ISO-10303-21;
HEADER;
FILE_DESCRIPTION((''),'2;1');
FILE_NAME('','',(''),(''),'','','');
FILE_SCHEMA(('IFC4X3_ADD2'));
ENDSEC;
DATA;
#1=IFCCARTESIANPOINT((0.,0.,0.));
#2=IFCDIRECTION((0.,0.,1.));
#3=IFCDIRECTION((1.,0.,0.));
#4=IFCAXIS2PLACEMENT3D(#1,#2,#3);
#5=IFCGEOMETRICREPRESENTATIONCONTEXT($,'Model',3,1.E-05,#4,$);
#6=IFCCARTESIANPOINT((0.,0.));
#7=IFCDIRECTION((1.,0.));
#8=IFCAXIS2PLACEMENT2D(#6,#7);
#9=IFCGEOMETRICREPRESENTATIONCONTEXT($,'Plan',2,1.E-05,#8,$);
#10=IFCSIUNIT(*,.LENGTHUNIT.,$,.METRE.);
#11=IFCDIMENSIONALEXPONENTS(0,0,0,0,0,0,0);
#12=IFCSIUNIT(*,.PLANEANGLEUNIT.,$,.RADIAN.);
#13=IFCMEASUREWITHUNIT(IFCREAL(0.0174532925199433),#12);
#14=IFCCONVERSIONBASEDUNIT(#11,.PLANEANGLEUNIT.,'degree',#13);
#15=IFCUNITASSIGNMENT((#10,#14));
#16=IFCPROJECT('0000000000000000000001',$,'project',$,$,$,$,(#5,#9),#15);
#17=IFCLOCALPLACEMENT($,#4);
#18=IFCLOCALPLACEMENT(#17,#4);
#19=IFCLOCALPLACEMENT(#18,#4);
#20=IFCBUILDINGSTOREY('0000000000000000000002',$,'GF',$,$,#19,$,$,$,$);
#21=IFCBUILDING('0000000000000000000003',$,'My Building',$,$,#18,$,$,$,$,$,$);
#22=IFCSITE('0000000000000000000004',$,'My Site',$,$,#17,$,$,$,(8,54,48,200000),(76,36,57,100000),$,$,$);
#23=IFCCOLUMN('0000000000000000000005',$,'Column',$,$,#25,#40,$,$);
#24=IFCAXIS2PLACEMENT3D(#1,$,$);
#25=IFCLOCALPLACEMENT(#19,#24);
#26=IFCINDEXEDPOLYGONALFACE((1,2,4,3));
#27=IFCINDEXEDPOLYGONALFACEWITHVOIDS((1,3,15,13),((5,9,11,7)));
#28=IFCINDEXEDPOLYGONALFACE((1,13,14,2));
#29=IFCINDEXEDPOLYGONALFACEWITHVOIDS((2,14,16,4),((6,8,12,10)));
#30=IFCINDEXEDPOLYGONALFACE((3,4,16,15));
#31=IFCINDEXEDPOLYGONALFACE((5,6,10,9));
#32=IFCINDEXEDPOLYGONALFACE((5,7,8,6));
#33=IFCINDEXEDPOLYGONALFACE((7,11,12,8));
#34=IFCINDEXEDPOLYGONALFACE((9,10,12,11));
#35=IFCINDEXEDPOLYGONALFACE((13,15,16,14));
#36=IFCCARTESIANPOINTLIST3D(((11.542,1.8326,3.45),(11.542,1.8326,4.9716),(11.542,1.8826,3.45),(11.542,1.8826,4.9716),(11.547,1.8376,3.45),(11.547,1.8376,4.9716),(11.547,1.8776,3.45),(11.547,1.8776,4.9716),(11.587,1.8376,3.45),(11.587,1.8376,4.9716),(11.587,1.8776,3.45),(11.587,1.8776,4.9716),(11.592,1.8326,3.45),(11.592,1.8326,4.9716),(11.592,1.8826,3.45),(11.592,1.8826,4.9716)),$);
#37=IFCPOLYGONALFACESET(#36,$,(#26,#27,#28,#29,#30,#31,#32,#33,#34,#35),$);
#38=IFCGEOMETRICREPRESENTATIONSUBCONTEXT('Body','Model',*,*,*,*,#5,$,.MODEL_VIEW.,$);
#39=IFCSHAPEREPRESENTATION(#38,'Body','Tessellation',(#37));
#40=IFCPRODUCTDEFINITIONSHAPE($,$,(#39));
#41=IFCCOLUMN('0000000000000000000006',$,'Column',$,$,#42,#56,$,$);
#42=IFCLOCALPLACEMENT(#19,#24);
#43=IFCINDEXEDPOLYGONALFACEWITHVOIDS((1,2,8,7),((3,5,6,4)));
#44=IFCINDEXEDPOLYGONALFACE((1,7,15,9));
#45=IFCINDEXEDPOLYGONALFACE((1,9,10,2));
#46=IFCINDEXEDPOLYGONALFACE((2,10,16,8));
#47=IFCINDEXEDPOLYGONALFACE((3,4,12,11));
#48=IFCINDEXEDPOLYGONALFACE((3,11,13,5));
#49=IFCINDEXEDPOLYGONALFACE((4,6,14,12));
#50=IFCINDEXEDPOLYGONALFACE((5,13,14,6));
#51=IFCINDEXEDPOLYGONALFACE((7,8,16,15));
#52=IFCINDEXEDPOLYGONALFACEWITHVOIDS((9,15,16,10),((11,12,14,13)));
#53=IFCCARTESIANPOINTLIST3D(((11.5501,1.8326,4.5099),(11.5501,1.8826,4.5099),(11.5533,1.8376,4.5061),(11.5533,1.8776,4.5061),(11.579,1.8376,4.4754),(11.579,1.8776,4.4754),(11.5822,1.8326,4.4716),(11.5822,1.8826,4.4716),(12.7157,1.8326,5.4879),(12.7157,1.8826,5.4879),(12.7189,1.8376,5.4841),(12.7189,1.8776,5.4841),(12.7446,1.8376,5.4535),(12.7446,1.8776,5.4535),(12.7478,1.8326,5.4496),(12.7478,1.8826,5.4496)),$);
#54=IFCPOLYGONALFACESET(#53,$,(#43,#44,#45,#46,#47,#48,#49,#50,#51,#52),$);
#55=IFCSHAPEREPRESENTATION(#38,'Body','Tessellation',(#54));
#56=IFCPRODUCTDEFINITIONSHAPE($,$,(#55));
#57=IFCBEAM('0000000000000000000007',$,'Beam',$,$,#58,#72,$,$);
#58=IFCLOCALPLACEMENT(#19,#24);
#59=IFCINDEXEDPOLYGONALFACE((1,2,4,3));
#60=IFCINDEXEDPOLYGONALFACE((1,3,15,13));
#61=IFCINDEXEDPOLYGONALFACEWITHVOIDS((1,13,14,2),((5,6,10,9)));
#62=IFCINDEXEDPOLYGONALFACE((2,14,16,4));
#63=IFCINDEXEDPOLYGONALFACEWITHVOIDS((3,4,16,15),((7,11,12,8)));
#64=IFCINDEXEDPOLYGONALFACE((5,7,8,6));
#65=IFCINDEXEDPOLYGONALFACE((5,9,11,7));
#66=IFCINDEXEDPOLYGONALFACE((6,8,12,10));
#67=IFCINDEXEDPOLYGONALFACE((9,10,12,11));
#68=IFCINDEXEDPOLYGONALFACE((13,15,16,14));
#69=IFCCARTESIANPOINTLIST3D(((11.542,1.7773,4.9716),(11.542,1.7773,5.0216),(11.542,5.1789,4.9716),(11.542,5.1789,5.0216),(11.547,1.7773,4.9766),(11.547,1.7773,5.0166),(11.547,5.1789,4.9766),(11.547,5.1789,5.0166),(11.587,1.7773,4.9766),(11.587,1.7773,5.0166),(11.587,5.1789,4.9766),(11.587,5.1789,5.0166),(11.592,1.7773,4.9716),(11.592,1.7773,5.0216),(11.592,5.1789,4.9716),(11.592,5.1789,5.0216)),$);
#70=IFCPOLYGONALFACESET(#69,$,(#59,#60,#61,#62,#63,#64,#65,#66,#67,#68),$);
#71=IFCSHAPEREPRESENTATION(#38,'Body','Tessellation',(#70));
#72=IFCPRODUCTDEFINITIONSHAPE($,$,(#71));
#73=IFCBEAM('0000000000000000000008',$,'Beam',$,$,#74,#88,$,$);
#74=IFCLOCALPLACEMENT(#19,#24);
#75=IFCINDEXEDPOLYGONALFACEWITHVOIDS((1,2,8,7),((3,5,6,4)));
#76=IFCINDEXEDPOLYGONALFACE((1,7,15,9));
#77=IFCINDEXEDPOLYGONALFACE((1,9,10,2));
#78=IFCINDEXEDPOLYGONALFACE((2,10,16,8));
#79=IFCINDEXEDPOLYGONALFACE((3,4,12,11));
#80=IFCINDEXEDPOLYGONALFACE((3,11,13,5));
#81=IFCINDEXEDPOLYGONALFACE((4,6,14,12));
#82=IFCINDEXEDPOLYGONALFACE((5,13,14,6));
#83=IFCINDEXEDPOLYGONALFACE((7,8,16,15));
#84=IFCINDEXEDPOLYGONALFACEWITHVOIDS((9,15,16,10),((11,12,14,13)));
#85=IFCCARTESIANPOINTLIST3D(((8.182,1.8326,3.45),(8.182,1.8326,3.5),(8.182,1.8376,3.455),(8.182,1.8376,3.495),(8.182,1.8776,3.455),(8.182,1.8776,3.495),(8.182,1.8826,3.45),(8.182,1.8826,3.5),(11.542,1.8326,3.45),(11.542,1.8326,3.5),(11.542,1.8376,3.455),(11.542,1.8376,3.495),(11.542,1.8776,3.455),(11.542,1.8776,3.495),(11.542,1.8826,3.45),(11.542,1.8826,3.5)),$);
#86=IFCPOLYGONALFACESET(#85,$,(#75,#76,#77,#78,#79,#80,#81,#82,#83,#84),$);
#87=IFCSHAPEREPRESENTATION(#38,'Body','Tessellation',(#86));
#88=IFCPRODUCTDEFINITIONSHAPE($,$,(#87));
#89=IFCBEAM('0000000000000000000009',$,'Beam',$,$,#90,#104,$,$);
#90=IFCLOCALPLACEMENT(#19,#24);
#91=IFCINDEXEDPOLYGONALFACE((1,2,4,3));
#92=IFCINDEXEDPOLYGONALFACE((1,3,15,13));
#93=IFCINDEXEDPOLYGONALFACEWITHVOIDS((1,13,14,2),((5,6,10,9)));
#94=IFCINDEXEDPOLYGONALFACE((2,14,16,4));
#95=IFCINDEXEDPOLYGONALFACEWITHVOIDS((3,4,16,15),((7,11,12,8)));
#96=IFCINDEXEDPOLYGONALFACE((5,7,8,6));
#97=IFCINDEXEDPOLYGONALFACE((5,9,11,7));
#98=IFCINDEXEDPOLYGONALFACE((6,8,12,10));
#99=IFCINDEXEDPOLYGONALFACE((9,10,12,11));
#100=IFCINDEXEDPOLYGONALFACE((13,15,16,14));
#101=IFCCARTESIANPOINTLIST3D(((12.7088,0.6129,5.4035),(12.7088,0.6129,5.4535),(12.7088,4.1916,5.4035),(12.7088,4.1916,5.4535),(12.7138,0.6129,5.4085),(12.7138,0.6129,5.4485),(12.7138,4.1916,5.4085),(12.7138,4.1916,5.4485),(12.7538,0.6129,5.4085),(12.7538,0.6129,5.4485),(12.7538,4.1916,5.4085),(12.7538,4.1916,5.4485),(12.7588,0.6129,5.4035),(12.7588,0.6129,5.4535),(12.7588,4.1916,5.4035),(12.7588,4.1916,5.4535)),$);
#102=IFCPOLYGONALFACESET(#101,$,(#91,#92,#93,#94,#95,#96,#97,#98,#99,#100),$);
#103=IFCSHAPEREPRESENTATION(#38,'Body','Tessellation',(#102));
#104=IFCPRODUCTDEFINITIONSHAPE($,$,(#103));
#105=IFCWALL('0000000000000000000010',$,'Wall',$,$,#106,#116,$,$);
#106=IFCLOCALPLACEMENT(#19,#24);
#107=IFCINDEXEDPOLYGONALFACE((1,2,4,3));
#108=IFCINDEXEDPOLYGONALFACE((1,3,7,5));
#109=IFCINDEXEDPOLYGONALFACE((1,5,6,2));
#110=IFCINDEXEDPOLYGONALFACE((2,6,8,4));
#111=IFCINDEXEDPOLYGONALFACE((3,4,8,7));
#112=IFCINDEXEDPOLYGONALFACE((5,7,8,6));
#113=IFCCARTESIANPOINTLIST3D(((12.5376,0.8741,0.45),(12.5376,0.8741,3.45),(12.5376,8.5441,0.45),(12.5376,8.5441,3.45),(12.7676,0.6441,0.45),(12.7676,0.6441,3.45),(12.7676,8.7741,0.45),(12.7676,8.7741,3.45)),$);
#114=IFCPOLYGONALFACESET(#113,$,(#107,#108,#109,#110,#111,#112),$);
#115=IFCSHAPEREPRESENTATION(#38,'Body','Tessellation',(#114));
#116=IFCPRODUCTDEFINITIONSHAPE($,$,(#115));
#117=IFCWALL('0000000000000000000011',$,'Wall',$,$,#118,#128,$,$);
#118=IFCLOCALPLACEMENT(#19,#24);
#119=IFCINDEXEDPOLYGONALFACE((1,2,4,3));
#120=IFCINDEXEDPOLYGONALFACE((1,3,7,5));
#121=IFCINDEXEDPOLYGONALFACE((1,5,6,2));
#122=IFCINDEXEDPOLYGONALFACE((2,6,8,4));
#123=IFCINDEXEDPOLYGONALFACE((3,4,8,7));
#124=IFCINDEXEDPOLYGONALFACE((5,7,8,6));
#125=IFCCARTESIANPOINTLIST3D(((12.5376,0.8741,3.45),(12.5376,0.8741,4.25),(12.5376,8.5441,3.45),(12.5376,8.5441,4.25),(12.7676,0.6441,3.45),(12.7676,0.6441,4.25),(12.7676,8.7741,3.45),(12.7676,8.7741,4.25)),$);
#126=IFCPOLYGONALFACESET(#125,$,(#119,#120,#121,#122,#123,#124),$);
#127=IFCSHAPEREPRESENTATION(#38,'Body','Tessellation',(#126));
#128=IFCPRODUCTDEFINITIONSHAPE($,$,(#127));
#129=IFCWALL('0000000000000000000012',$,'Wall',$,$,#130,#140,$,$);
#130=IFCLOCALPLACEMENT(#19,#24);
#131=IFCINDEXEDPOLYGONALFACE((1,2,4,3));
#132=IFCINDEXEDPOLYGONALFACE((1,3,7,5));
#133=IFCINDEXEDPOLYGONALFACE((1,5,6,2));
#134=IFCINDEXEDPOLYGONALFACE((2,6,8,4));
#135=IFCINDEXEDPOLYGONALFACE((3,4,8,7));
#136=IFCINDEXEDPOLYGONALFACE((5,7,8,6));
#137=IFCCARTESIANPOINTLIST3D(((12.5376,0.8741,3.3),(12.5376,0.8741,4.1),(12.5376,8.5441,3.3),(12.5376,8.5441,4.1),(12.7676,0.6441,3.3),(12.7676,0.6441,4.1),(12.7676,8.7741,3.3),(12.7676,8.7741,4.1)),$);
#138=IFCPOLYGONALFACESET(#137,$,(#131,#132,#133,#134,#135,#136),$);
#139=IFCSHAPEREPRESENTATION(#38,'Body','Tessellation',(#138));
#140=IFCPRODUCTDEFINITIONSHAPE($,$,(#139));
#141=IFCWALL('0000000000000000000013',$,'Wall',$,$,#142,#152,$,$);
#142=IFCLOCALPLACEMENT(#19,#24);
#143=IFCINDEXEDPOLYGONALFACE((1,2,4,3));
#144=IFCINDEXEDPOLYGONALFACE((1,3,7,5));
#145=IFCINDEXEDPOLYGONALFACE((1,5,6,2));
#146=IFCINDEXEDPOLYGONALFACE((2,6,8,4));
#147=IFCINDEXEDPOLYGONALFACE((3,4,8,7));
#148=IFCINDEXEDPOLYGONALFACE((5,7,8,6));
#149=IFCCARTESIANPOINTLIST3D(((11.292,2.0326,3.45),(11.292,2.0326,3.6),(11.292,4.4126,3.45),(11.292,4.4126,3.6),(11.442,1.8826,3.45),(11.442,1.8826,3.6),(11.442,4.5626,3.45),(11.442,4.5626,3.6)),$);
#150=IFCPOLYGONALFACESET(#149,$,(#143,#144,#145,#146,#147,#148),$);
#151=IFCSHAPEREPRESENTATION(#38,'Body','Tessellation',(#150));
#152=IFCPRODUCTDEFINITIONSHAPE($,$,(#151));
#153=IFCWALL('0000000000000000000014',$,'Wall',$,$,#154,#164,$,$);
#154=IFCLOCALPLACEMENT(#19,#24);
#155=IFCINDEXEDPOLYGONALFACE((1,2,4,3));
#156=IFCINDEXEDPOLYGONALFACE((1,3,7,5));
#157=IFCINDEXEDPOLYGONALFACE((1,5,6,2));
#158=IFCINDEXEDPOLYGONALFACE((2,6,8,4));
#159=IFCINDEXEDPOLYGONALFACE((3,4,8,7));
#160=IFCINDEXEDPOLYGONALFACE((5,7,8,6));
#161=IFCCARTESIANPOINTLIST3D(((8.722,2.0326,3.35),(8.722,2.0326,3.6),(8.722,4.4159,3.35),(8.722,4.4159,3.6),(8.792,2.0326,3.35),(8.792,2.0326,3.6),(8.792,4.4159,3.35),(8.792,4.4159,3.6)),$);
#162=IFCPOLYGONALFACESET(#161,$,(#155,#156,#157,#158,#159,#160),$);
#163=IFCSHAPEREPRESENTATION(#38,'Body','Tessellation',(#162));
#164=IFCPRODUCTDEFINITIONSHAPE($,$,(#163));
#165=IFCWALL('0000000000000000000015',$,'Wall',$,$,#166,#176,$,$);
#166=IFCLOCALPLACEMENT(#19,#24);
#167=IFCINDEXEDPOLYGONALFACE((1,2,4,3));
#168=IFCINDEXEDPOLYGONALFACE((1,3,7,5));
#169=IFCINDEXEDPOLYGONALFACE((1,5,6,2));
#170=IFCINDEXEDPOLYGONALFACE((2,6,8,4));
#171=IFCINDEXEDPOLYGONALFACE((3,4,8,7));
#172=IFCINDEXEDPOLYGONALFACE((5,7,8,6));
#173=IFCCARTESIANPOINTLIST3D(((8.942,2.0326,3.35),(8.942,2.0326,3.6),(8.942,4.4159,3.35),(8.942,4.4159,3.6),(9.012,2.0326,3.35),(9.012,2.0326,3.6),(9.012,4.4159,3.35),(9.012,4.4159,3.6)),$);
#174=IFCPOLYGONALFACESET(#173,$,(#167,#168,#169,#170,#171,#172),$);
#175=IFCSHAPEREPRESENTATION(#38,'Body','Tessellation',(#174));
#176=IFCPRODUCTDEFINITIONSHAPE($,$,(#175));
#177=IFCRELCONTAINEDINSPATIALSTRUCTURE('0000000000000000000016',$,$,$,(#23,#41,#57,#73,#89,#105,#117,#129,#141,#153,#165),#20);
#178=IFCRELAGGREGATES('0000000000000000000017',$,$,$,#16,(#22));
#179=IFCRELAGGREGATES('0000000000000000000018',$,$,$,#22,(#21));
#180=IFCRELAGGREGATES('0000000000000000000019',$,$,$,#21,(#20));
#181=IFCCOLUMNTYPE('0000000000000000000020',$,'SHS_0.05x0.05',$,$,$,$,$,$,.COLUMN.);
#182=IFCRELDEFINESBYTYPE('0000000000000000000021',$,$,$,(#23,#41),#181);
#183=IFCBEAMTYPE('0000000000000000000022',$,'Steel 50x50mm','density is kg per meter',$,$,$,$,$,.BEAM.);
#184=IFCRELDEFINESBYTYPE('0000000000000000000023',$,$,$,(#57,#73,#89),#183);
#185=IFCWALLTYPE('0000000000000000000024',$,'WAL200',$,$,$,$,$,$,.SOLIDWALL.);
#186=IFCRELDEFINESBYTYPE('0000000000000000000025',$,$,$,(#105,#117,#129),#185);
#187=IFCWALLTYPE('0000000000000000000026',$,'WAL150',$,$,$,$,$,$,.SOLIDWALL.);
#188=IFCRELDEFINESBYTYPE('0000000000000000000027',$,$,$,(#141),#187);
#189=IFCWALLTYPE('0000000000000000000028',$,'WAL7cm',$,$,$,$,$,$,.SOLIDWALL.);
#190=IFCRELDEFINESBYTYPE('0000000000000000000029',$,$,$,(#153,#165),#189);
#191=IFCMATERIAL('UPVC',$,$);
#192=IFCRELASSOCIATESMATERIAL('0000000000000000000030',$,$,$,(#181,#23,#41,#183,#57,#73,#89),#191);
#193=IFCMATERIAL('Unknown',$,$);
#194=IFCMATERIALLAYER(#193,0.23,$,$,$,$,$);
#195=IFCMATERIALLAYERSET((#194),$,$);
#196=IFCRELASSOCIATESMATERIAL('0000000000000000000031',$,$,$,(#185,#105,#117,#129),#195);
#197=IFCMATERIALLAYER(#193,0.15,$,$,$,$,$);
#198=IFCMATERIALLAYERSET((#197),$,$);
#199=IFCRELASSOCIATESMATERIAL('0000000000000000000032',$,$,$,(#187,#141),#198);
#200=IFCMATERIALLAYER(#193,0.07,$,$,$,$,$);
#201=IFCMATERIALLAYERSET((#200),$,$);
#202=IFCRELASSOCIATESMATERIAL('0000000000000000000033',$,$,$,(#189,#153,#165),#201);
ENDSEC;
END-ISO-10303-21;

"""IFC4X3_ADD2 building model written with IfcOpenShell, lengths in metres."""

from ifc_helpers import new_model, entity, si_unit, converted_unit, frame, origin_with_axes, origin_2d_with_axis, place, context, subcontext, project, spatial, line, indexed_curve, hollow_rectangle, outline, extrude, material, layer, layer_set, layer_usage, material_profile, profile_set, profile_usage, type_object, element, save


model = new_model("IFC4X3_ADD2")

# Units and contexts
model_context = context("Model", 3, precision=1e-05, world=origin_with_axes())
plan_context = context("Plan", 2, precision=1e-05, world=origin_2d_with_axis())
body_context = subcontext(model_context, "Body", "Model", "MODEL_VIEW")
ifc_project = project(units=[si_unit("LENGTHUNIT", "METRE"), converted_unit("PLANEANGLEUNIT", "degree", entity("IfcReal", 0.0174532925199433), si_unit("PLANEANGLEUNIT", "RADIAN"), dimensions=[0, 0, 0, 0, 0, 0, 0])], contexts=[model_context, plan_context])

# Site, building, storey
site_placement = place(None, origin_with_axes())
site = spatial("IfcSite", under=ifc_project, at=site_placement, Name="My Site", RefLatitude=(8, 54, 48, 200000), RefLongitude=(76, 36, 57, 100000))
building_placement = place(site_placement, origin_with_axes())
building = spatial("IfcBuilding", under=site, at=building_placement, Name="My Building")
storey_placement = place(building_placement, origin_with_axes())
storey = spatial("IfcBuildingStorey", under=building, at=storey_placement, Name="GF")

# Columns
ifc_material_1 = material(Name="UPVC")
ifc_material_profile_1 = material_profile(ifc_material_1, hollow_rectangle(XDim=0.05, YDim=0.05, WallThickness=0.005))
ifc_profile_set_1 = profile_set([ifc_material_profile_1])
ifc_profile_usage_1 = profile_usage(ifc_profile_set_1, cardinal=5)
column_type = type_object("IfcColumnType", Name="SHS_0.05x0.05", PredefinedType="COLUMN", material=ifc_profile_set_1)
column_1_placement = place(storey_placement, frame((11.567, 1.8576, 3.45), z_axis=(0.0, 0.0, 1.0), x_axis=(1.0, 0.0, 0.0)))
element("IfcColumn", 1, at=column_1_placement, inside=storey, type_object=column_type, material=ifc_profile_usage_1, Name="Column", context=body_context, shape_type="SweptSolid", body=[
    extrude(hollow_rectangle(XDim=0.05, YDim=0.05, WallThickness=0.005), origin_with_axes(), (0.0, 0.0, 1.0), 1.5216),
])
ifc_profile_usage_2 = profile_usage(ifc_profile_set_1, cardinal=5)
column_2_placement = place(storey_placement, frame((11.5662, 1.8576, 4.4907), z_axis=(0.766045, 0.0, 0.642787), x_axis=(0.0, 1.0, 0.0)))
element("IfcColumn", 2, at=column_2_placement, inside=storey, type_object=column_type, material=ifc_profile_usage_2, Name="Column", context=body_context, shape_type="SweptSolid", body=[
    extrude(hollow_rectangle(XDim=0.05, YDim=0.05, WallThickness=0.005), origin_with_axes(), (0.0, 0.0, 1.0), 1.5216),
])

# Beams
ifc_material_profile_2 = material_profile(ifc_material_1, hollow_rectangle(XDim=0.05, YDim=0.05, WallThickness=0.005))
ifc_profile_set_2 = profile_set([ifc_material_profile_2])
ifc_profile_usage_3 = profile_usage(ifc_profile_set_2, cardinal=5)
beam_type = type_object("IfcBeamType", Name="Steel 50x50mm", Description="density is kg per meter", PredefinedType="BEAM", material=ifc_profile_set_2)
beam_1_placement = place(storey_placement, frame((11.567, 5.1789, 4.9966), z_axis=(0.0, -1.0, 0.0), x_axis=(1.0, 0.0, 0.0)))
element("IfcBeam", 3, at=beam_1_placement, inside=storey, type_object=beam_type, material=ifc_profile_usage_3, Name="Beam", context=body_context, shape_type="SweptSolid", body=[
    extrude(hollow_rectangle(XDim=0.05, YDim=0.05, WallThickness=0.005), origin_with_axes(), (0.0, 0.0, 1.0), 3.4016),
])
ifc_profile_usage_4 = profile_usage(ifc_profile_set_2, cardinal=5)
beam_2_placement = place(storey_placement, frame((11.542, 1.8576, 3.475), z_axis=(-1.0, 0.0, 0.0), x_axis=(0.0, -1.0, 0.0)))
element("IfcBeam", 4, at=beam_2_placement, inside=storey, type_object=beam_type, material=ifc_profile_usage_4, Name="Beam", context=body_context, shape_type="SweptSolid", body=[
    extrude(hollow_rectangle(XDim=0.05, YDim=0.05, WallThickness=0.005), origin_with_axes(), (0.0, 0.0, 1.0), 3.36),
])
ifc_profile_usage_5 = profile_usage(ifc_profile_set_2, cardinal=5)
beam_3_placement = place(storey_placement, frame((12.7338, 4.1916, 5.4285), z_axis=(0.0, -1.0, 0.0), x_axis=(1.0, 0.0, 0.0)))
element("IfcBeam", 5, at=beam_3_placement, inside=storey, type_object=beam_type, material=ifc_profile_usage_5, Name="Beam", context=body_context, shape_type="SweptSolid", body=[
    extrude(hollow_rectangle(XDim=0.05, YDim=0.05, WallThickness=0.005), origin_with_axes(), (0.0, 0.0, 1.0), 3.5787),
])

# Walls
ifc_material_2 = material(Name="Unknown")
ifc_layer_1 = layer(ifc_material_2, 0.23)
ifc_layer_set_1 = layer_set([ifc_layer_1])
ifc_layer_usage_1 = layer_usage(ifc_layer_set_1, "AXIS2", "POSITIVE", 0.0)
wall_type_1 = type_object("IfcWallType", Name="WAL200", PredefinedType="SOLIDWALL", material=ifc_layer_set_1)
wall_1_placement = place(storey_placement, frame((12.5376, 8.5441, 0.45), z_axis=(0.0, 0.0, 1.0), x_axis=(0.0, -1.0, 0.0)))
element("IfcWall", 6, at=wall_1_placement, inside=storey, type_object=wall_type_1, material=ifc_layer_usage_1, Name="Wall", context=body_context, shape_type="SweptSolid", body=[
    extrude(outline(indexed_curve([(0.0, 0.0), (-0.23, 0.23), (7.9, 0.23), (7.67, 0.0)], segments=[line(1, 2, 3, 4, 1)])), origin_with_axes(), (0.0, 0.0, 1.0), 3.0),
])
ifc_layer_usage_2 = layer_usage(ifc_layer_set_1, "AXIS2", "POSITIVE", 0.0)
wall_2_placement = place(storey_placement, frame((12.5376, 8.5441, 3.45), z_axis=(0.0, 0.0, 1.0), x_axis=(0.0, -1.0, 0.0)))
element("IfcWall", 7, at=wall_2_placement, inside=storey, type_object=wall_type_1, material=ifc_layer_usage_2, Name="Wall", context=body_context, shape_type="SweptSolid", body=[
    extrude(outline(indexed_curve([(0.0, 0.0), (-0.23, 0.23), (7.9, 0.23), (7.67, 0.0)], segments=[line(1, 2, 3, 4, 1)])), origin_with_axes(), (0.0, 0.0, 1.0), 0.8),
])
ifc_layer_usage_3 = layer_usage(ifc_layer_set_1, "AXIS2", "POSITIVE", 0.0)
wall_3_placement = place(storey_placement, frame((12.5376, 8.5441, 3.3), z_axis=(0.0, 0.0, 1.0), x_axis=(0.0, -1.0, 0.0)))
element("IfcWall", 8, at=wall_3_placement, inside=storey, type_object=wall_type_1, material=ifc_layer_usage_3, Name="Wall", context=body_context, shape_type="SweptSolid", body=[
    extrude(outline(indexed_curve([(0.0, 0.0), (-0.23, 0.23), (7.9, 0.23), (7.67, 0.0)], segments=[line(1, 2, 3, 4, 1)])), origin_with_axes(), (0.0, 0.0, 1.0), 0.8),
])
ifc_layer_2 = layer(ifc_material_2, 0.15)
ifc_layer_set_2 = layer_set([ifc_layer_2])
ifc_layer_usage_4 = layer_usage(ifc_layer_set_2, "AXIS2", "POSITIVE", 0.0)
wall_type_2 = type_object("IfcWallType", Name="WAL150", PredefinedType="SOLIDWALL", material=ifc_layer_set_2)
wall_4_placement = place(storey_placement, frame((11.292, 4.4126, 3.45), z_axis=(0.0, 0.0, 1.0), x_axis=(0.0, -1.0, 0.0)))
element("IfcWall", 9, at=wall_4_placement, inside=storey, type_object=wall_type_2, material=ifc_layer_usage_4, Name="Wall", context=body_context, shape_type="SweptSolid", body=[
    extrude(outline(indexed_curve([(0.0, 0.0), (-0.15, 0.15), (2.53, 0.15), (2.38, 0.0)], segments=[line(1, 2, 3, 4, 1)])), origin_with_axes(), (0.0, 0.0, 1.0), 0.15),
])
ifc_layer_3 = layer(ifc_material_2, 0.07)
ifc_layer_set_3 = layer_set([ifc_layer_3])
ifc_layer_usage_5 = layer_usage(ifc_layer_set_3, "AXIS2", "NEGATIVE", 0.0)
wall_type_3 = type_object("IfcWallType", Name="WAL7cm", PredefinedType="SOLIDWALL", material=ifc_layer_set_3)
wall_5_placement = place(storey_placement, frame((8.792, 4.4159, 3.35), z_axis=(0.0, 0.0, 1.0), x_axis=(0.0, -1.0, 0.0)))
element("IfcWall", 10, at=wall_5_placement, inside=storey, type_object=wall_type_3, material=ifc_layer_usage_5, Name="Wall", context=body_context, shape_type="SweptSolid", body=[
    extrude(outline(indexed_curve([(0.0, -0.07), (0.0, 0.0), (2.3833, 0.0), (2.3833, -0.07)], segments=[line(1, 2, 3, 4, 1)])), origin_with_axes(), (0.0, 0.0, 1.0), 0.25),
])
ifc_layer_usage_6 = layer_usage(ifc_layer_set_3, "AXIS2", "NEGATIVE", 0.0)
wall_6_placement = place(storey_placement, frame((9.012, 4.4159, 3.35), z_axis=(0.0, 0.0, 1.0), x_axis=(0.0, -1.0, 0.0)))
element("IfcWall", 11, at=wall_6_placement, inside=storey, type_object=wall_type_3, material=ifc_layer_usage_6, Name="Wall", context=body_context, shape_type="SweptSolid", body=[
    extrude(outline(indexed_curve([(0.0, -0.07), (0.0, 0.0), (2.3833, 0.0), (2.3833, -0.07)], segments=[line(1, 2, 3, 4, 1)])), origin_with_axes(), (0.0, 0.0, 1.0), 0.25),
])

save(model, "model.ifc")
